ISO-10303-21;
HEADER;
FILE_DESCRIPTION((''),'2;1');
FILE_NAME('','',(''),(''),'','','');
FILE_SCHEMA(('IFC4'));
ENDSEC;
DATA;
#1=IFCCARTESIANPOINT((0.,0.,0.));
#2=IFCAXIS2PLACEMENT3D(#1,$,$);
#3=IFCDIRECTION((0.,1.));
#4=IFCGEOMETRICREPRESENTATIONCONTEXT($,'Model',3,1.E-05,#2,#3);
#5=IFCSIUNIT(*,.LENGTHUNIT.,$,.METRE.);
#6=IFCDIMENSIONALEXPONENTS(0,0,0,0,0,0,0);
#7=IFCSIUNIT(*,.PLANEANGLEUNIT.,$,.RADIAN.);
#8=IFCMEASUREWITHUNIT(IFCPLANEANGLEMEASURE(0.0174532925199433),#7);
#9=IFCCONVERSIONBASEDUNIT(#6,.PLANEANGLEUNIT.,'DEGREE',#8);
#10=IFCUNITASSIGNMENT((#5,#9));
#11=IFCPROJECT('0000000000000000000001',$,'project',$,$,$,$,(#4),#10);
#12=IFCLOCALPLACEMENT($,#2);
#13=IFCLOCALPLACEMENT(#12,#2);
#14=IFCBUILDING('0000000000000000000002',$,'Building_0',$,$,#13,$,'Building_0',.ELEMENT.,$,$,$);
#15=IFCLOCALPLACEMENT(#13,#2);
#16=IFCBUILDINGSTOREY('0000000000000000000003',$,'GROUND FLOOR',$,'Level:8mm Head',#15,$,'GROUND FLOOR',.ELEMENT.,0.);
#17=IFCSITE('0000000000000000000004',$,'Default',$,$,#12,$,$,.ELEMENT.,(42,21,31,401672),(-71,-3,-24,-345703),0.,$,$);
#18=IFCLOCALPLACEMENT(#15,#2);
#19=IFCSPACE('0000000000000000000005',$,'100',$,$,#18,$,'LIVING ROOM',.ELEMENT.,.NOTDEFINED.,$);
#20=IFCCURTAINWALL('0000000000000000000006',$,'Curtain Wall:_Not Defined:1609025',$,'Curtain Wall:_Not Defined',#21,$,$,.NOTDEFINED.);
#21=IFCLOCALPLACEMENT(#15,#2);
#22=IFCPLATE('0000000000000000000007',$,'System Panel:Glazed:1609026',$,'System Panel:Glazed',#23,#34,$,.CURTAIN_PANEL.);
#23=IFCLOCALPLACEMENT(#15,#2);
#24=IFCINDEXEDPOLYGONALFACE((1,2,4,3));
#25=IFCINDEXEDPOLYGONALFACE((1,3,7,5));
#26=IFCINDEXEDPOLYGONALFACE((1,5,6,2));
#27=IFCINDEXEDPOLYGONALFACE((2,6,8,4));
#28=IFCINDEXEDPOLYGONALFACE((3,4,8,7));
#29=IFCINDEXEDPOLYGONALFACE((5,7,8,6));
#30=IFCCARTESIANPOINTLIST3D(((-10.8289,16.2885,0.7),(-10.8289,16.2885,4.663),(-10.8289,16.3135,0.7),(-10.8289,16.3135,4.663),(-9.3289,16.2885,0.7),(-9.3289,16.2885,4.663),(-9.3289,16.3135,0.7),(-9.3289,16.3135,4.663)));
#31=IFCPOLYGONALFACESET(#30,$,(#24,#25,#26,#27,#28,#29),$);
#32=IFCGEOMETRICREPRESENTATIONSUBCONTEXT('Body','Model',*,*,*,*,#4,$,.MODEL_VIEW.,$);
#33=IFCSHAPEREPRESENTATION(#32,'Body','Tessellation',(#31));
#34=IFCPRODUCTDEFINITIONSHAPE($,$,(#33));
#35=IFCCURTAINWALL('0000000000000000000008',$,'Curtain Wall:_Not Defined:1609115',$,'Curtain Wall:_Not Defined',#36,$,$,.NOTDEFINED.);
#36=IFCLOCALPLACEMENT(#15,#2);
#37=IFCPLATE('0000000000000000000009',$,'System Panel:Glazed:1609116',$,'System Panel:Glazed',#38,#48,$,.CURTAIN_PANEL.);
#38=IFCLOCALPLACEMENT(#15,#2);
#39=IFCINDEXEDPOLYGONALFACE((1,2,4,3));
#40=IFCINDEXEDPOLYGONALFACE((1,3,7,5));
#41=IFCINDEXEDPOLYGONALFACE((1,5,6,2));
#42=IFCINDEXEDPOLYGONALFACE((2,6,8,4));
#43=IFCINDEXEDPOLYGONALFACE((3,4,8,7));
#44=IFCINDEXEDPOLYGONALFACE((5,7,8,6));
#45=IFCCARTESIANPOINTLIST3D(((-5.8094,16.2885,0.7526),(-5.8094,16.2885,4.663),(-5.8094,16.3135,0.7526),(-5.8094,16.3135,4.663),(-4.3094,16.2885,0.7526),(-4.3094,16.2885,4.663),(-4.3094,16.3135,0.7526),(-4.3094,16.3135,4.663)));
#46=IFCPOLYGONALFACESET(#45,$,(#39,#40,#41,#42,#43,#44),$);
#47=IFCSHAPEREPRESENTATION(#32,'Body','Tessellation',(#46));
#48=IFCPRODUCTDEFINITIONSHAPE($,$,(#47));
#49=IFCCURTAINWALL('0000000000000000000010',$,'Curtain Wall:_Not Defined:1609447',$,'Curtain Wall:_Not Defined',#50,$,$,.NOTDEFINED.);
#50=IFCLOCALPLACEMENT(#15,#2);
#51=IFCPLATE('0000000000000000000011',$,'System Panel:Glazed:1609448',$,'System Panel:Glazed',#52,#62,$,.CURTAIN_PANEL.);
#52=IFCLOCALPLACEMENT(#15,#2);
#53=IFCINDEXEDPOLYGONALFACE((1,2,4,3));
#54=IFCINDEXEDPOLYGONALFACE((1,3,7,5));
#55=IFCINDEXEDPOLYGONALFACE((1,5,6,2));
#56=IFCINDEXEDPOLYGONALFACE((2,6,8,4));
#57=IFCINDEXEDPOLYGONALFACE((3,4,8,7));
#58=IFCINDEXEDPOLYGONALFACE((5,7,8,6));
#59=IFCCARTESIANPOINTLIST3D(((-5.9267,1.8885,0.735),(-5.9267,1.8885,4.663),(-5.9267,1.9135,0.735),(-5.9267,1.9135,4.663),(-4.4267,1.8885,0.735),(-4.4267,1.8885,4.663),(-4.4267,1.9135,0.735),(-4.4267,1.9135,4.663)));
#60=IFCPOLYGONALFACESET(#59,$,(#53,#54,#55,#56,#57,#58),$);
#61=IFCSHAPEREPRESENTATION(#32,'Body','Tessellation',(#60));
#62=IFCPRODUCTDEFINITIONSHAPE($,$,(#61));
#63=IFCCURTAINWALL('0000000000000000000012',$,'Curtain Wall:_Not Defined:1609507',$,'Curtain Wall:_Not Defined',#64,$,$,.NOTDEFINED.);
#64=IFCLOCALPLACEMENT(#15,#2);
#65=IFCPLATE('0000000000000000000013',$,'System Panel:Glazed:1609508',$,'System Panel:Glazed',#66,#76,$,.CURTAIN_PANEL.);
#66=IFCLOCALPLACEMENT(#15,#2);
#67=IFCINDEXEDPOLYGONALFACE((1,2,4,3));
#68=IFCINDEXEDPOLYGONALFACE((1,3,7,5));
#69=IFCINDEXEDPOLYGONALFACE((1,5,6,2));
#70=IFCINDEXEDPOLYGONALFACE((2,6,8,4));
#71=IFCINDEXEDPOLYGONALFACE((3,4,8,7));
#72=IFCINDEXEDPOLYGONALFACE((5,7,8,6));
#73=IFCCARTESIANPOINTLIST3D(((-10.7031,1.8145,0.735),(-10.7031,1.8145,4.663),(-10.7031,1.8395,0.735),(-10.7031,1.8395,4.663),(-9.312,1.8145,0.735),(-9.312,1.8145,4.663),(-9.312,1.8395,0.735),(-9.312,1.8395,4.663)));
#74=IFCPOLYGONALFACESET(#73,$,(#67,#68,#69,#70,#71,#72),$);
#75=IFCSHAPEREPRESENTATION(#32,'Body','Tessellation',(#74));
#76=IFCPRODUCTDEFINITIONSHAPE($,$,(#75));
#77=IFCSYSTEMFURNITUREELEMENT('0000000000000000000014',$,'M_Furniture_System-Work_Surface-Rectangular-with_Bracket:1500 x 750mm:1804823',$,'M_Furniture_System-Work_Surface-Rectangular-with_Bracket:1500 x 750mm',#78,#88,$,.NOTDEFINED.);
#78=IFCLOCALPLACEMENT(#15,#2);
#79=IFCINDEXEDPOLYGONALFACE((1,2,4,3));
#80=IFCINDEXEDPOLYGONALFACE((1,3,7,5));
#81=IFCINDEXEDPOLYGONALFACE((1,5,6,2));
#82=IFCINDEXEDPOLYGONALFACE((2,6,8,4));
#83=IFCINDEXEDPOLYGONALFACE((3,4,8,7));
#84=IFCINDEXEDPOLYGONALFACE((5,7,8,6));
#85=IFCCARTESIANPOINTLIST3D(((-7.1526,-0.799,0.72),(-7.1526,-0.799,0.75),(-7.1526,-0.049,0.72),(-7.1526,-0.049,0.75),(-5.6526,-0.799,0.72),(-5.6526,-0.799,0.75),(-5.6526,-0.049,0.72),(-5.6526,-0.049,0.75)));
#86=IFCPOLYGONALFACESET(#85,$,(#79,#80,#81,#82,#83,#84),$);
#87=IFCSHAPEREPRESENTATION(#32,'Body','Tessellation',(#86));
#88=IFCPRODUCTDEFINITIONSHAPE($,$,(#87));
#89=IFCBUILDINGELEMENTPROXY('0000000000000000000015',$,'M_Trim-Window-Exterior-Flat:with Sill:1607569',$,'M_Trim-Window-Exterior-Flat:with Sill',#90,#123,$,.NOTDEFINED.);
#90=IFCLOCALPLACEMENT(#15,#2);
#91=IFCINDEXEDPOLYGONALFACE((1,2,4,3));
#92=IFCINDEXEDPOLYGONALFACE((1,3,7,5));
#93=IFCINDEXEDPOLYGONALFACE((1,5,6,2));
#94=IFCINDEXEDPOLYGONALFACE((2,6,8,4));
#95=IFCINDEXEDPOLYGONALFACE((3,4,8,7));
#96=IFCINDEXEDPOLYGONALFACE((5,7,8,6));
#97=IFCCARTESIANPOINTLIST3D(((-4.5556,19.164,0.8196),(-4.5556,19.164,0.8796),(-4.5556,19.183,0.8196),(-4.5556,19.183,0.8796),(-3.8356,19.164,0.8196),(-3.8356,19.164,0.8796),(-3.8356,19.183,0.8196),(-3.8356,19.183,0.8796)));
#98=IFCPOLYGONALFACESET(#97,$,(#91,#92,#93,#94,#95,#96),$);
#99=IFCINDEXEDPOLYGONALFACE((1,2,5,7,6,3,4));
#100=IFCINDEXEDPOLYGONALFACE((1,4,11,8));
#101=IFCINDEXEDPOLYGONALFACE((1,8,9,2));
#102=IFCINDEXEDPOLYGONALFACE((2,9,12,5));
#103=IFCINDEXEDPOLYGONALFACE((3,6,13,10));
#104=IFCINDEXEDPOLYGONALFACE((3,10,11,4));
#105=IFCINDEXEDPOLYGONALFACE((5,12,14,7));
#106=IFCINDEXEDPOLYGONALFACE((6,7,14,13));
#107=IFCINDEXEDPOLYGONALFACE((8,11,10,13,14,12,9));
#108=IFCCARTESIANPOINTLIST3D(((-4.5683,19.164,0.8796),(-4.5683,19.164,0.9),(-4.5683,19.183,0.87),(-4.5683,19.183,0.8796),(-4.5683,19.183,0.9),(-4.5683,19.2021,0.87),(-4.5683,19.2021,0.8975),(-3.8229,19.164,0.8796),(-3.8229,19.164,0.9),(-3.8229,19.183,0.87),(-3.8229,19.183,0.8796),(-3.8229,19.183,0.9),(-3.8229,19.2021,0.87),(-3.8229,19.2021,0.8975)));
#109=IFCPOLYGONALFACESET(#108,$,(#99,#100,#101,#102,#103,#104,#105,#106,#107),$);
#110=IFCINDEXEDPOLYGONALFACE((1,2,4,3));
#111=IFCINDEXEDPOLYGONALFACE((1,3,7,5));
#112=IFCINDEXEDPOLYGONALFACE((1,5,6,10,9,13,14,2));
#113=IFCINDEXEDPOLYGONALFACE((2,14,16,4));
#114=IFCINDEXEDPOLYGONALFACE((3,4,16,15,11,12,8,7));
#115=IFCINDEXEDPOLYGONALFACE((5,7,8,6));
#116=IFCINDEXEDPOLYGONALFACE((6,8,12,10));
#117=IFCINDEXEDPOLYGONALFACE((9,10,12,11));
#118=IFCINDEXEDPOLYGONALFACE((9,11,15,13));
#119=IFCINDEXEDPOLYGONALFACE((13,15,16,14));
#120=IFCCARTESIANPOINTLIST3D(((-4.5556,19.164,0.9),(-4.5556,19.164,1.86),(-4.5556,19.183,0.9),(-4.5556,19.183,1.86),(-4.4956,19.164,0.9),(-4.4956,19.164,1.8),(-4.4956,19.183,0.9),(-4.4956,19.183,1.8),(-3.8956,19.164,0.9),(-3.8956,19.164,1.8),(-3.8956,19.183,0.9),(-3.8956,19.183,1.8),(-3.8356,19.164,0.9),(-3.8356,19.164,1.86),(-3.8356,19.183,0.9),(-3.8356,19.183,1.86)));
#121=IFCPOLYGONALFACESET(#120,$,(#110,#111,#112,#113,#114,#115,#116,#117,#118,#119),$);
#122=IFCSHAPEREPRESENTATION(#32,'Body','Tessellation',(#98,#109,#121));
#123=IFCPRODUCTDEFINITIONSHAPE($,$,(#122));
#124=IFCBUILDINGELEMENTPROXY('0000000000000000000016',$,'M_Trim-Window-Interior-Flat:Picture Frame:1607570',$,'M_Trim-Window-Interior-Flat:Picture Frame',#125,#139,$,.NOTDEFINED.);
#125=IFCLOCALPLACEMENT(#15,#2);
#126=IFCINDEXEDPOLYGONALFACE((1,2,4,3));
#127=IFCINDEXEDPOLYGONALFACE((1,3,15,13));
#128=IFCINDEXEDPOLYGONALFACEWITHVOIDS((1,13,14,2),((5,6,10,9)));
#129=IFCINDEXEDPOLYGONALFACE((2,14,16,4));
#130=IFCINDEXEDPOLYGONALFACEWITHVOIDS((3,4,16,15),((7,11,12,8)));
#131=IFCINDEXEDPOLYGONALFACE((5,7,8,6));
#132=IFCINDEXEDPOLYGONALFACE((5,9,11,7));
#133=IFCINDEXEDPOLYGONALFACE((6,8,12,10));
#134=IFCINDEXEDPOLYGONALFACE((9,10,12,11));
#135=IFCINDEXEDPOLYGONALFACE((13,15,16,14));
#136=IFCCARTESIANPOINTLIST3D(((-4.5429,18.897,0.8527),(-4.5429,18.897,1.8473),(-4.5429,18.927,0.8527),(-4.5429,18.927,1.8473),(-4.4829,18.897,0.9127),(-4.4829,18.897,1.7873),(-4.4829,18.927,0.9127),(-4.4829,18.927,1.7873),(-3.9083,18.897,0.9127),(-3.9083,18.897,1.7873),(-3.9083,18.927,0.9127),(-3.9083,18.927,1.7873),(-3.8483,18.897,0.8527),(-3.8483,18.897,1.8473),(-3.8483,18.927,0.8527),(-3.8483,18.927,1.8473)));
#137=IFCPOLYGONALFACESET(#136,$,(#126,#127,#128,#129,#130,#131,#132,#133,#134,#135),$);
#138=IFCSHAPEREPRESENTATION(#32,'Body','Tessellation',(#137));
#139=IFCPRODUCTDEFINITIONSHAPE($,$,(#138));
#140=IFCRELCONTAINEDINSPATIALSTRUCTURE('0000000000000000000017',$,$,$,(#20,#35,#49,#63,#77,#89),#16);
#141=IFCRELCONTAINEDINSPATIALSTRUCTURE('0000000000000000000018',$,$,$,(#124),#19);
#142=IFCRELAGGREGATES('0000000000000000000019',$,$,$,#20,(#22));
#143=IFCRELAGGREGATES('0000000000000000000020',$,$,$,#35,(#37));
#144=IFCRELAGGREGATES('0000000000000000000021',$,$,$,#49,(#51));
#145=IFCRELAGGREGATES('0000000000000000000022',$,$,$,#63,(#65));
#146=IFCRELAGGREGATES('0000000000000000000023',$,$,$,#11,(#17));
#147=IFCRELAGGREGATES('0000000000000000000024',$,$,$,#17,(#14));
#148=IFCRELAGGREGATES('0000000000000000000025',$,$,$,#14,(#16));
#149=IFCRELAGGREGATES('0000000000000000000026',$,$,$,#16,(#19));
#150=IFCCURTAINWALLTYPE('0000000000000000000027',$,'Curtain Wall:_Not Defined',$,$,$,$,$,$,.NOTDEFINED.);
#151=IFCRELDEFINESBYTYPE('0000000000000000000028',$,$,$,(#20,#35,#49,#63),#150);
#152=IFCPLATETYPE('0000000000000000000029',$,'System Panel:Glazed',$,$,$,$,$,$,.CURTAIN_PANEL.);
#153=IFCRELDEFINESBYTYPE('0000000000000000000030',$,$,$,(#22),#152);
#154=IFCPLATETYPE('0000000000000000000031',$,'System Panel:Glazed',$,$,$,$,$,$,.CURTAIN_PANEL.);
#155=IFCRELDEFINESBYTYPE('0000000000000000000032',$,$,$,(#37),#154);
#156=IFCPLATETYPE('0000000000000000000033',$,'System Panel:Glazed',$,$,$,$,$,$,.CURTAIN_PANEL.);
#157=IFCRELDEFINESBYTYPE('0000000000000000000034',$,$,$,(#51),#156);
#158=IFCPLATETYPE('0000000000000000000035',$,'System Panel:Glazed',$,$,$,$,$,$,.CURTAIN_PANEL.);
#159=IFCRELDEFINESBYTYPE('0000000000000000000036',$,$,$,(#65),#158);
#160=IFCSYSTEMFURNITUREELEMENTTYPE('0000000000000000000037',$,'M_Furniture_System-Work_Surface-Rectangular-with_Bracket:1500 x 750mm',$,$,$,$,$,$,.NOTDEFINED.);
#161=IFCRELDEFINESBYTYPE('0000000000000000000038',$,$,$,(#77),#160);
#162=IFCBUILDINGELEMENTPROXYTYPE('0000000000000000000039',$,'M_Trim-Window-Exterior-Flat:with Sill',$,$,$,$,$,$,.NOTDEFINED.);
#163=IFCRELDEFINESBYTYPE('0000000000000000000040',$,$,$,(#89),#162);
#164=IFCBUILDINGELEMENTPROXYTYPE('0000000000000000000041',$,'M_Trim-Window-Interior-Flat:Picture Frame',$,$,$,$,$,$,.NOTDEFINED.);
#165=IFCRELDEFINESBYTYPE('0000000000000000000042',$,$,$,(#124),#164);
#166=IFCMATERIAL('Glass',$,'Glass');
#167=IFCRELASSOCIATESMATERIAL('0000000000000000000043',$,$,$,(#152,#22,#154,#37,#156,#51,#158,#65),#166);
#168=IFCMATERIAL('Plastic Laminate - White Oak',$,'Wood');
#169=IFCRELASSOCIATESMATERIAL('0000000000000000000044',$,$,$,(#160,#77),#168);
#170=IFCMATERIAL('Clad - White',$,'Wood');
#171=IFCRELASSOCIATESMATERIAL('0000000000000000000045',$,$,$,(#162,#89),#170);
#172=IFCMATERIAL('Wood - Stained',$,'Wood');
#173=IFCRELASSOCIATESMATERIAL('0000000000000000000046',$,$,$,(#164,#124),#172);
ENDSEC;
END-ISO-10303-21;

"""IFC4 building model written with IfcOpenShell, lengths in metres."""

from ifc_helpers import new_model, entity, si_unit, converted_unit, direction, frame, origin, place, context, subcontext, project, spatial, indexed_curve, outline, extrude, source, transform, mapped, material, type_object, type_shapes, element, aggregate, save


model = new_model("IFC4")

# Units and contexts
model_context = context("Model", 3, precision=1e-05, world=origin(), true_north=direction((0.0, 1.0)))
body_context = subcontext(model_context, "Body", "Model", "MODEL_VIEW")
ifc_project = project(units=[si_unit("LENGTHUNIT", "METRE"), converted_unit("PLANEANGLEUNIT", "DEGREE", entity("IfcPlaneAngleMeasure", 0.0174532925199433), si_unit("PLANEANGLEUNIT", "RADIAN"), dimensions=[0, 0, 0, 0, 0, 0, 0])], contexts=[model_context])

# Site, building, storey
site_placement = place(None, origin())
site = spatial("IfcSite", under=ifc_project, at=site_placement, Name="Default", CompositionType="ELEMENT", RefLatitude=(42, 21, 31, 401672), RefLongitude=(-71, -3, -24, -345703), RefElevation=0.0)
building_placement = place(site_placement, origin())
building = spatial("IfcBuilding", under=site, at=building_placement, Name="Building_0", LongName="Building_0", CompositionType="ELEMENT")
storey_placement = place(building_placement, origin())
storey = spatial("IfcBuildingStorey", under=building, at=storey_placement, Name="GROUND FLOOR", ObjectType="Level:8mm Head", LongName="GROUND FLOOR", CompositionType="ELEMENT", Elevation=0.0)

# Curtain walls, plates
curtain_wall_type = type_object("IfcCurtainWallType", Name="Curtain Wall:_Not Defined", PredefinedType="NOTDEFINED")
curtain_wall_1_placement = place(storey_placement, origin())
curtain_wall_1 = element("IfcCurtainWall", 1, at=curtain_wall_1_placement, inside=storey, type_object=curtain_wall_type, Name="Curtain Wall:_Not Defined:1609025", ObjectType="Curtain Wall:_Not Defined", PredefinedType="NOTDEFINED")
ifc_material_1 = material(Name="Glass", Category="Glass")
plate_type_1 = type_object("IfcPlateType", Name="System Panel:Glazed", PredefinedType="CURTAIN_PANEL", material=ifc_material_1)
shared_shape_1 = source(origin(), body_context, "Body", "SweptSolid", [
    extrude(outline(indexed_curve([(-0.0125, -0.75), (0.0125, -0.75), (0.0125, 0.75), (-0.0125, 0.75), (-0.0125, -0.75)], self_intersect=False)), frame((0.0, 0.037, 0.0), z_axis=(0.0, 0.0, 1.0), x_axis=(0.0, 1.0, 0.0)), (0.0, 0.0, 1.0), 3.963),
])
type_shapes(plate_type_1, [shared_shape_1])
plate_1_placement = place(curtain_wall_1_placement, frame((-10.0789, 16.264, 0.7)))
plate_1 = element("IfcPlate", 2, at=plate_1_placement, type_object=plate_type_1, material=ifc_material_1, Name="System Panel:Glazed:1609026", ObjectType="System Panel:Glazed", PredefinedType="CURTAIN_PANEL", context=body_context, shape_type="MappedRepresentation", body=[
    mapped(shared_shape_1, transform((0.0, 0.0, 0.0), scale=1.0)),
])
aggregate(curtain_wall_1, [plate_1])
curtain_wall_2_placement = place(storey_placement, origin())
curtain_wall_2 = element("IfcCurtainWall", 3, at=curtain_wall_2_placement, inside=storey, type_object=curtain_wall_type, Name="Curtain Wall:_Not Defined:1609115", ObjectType="Curtain Wall:_Not Defined", PredefinedType="NOTDEFINED")
plate_type_2 = type_object("IfcPlateType", Name="System Panel:Glazed", PredefinedType="CURTAIN_PANEL", material=ifc_material_1)
shared_shape_2 = source(origin(), body_context, "Body", "SweptSolid", [
    extrude(outline(indexed_curve([(-0.0125, -0.75), (0.0125, -0.75), (0.0125, 0.75), (-0.0125, 0.75), (-0.0125, -0.75)], self_intersect=False)), frame((0.0, 0.037, 0.0), z_axis=(0.0, 0.0, 1.0), x_axis=(0.0, 1.0, 0.0)), (0.0, 0.0, 1.0), 3.9104),
])
type_shapes(plate_type_2, [shared_shape_2])
plate_2_placement = place(curtain_wall_2_placement, frame((-5.0594, 16.264, 0.7526)))
plate_2 = element("IfcPlate", 4, at=plate_2_placement, type_object=plate_type_2, material=ifc_material_1, Name="System Panel:Glazed:1609116", ObjectType="System Panel:Glazed", PredefinedType="CURTAIN_PANEL", context=body_context, shape_type="MappedRepresentation", body=[
    mapped(shared_shape_2, transform((0.0, 0.0, 0.0), scale=1.0)),
])
aggregate(curtain_wall_2, [plate_2])
curtain_wall_3_placement = place(storey_placement, origin())
curtain_wall_3 = element("IfcCurtainWall", 5, at=curtain_wall_3_placement, inside=storey, type_object=curtain_wall_type, Name="Curtain Wall:_Not Defined:1609447", ObjectType="Curtain Wall:_Not Defined", PredefinedType="NOTDEFINED")
plate_type_3 = type_object("IfcPlateType", Name="System Panel:Glazed", PredefinedType="CURTAIN_PANEL", material=ifc_material_1)
shared_shape_3 = source(origin(), body_context, "Body", "SweptSolid", [
    extrude(outline(indexed_curve([(-0.0125, -0.75), (0.0125, -0.75), (0.0125, 0.75), (-0.0125, 0.75), (-0.0125, -0.75)], self_intersect=False)), frame((0.0, 0.037, 0.0), z_axis=(0.0, 0.0, 1.0), x_axis=(0.0, 1.0, 0.0)), (0.0, 0.0, 1.0), 3.928),
])
type_shapes(plate_type_3, [shared_shape_3])
plate_3_placement = place(curtain_wall_3_placement, frame((-5.1767, 1.864, 0.735)))
plate_3 = element("IfcPlate", 6, at=plate_3_placement, type_object=plate_type_3, material=ifc_material_1, Name="System Panel:Glazed:1609448", ObjectType="System Panel:Glazed", PredefinedType="CURTAIN_PANEL", context=body_context, shape_type="MappedRepresentation", body=[
    mapped(shared_shape_3, transform((0.0, 0.0, 0.0), scale=1.0)),
])
aggregate(curtain_wall_3, [plate_3])
curtain_wall_4_placement = place(storey_placement, origin())
curtain_wall_4 = element("IfcCurtainWall", 7, at=curtain_wall_4_placement, inside=storey, type_object=curtain_wall_type, Name="Curtain Wall:_Not Defined:1609507", ObjectType="Curtain Wall:_Not Defined", PredefinedType="NOTDEFINED")
plate_type_4 = type_object("IfcPlateType", Name="System Panel:Glazed", PredefinedType="CURTAIN_PANEL", material=ifc_material_1)
shared_shape_4 = source(origin(), body_context, "Body", "SweptSolid", [
    extrude(outline(indexed_curve([(-0.0125, -0.6955), (0.0125, -0.6955), (0.0125, 0.6955), (-0.0125, 0.6955), (-0.0125, -0.6955)], self_intersect=False)), frame((0.0, 0.037, 0.0), z_axis=(0.0, 0.0, 1.0), x_axis=(0.0, 1.0, 0.0)), (0.0, 0.0, 1.0), 3.928),
])
type_shapes(plate_type_4, [shared_shape_4])
plate_4_placement = place(curtain_wall_4_placement, frame((-10.0076, 1.864, 0.735), z_axis=(0.0, 0.0, 1.0), x_axis=(-1.0, 0.0, 0.0)))
plate_4 = element("IfcPlate", 8, at=plate_4_placement, type_object=plate_type_4, material=ifc_material_1, Name="System Panel:Glazed:1609508", ObjectType="System Panel:Glazed", PredefinedType="CURTAIN_PANEL", context=body_context, shape_type="MappedRepresentation", body=[
    mapped(shared_shape_4, transform((0.0, 0.0, 0.0), scale=1.0)),
])
aggregate(curtain_wall_4, [plate_4])

# System furniture element
ifc_material_2 = material(Name="Plastic Laminate - White Oak", Category="Wood")
system_furniture_element_type_1 = type_object("IfcSystemFurnitureElementType", Name="M_Furniture_System-Work_Surface-Rectangular-with_Bracket:1500 x 750mm", PredefinedType="NOTDEFINED", material=ifc_material_2)
shared_shape_5 = source(origin(), body_context, "Body", "SweptSolid", [
    extrude(outline(indexed_curve([(-0.75, -0.375), (0.75, -0.375), (0.75, 0.375), (-0.75, 0.375), (-0.75, -0.375)], self_intersect=False)), frame((0.75, -0.375, 0.72), z_axis=(0.0, 0.0, 1.0), x_axis=(-1.0, 0.0, 0.0)), (0.0, 0.0, 1.0), 0.03),
])
type_shapes(system_furniture_element_type_1, [shared_shape_5])
placement = place(storey_placement, origin())
system_furniture_element_1_placement = place(placement, frame((-7.1526, -0.049, 0.0)))
element("IfcSystemFurnitureElement", 9, at=system_furniture_element_1_placement, inside=storey, type_object=system_furniture_element_type_1, material=ifc_material_2, Name="M_Furniture_System-Work_Surface-Rectangular-with_Bracket:1500 x 750mm:1804823", ObjectType="M_Furniture_System-Work_Surface-Rectangular-with_Bracket:1500 x 750mm", PredefinedType="NOTDEFINED", context=body_context, shape_type="MappedRepresentation", body=[
    mapped(shared_shape_5, transform((0.0, 0.0, 0.0), scale=1.0)),
])

# Building element proxy
ifc_material_3 = material(Name="Clad - White", Category="Wood")
building_element_proxy_type_1 = type_object("IfcBuildingElementProxyType", Name="M_Trim-Window-Exterior-Flat:with Sill", PredefinedType="NOTDEFINED", material=ifc_material_3)
shared_shape_6 = source(origin(), body_context, "Body", "SweptSolid", [
    extrude(outline(indexed_curve([(-0.03, -0.36), (0.03, -0.36), (0.03, 0.36), (-0.03, 0.36), (-0.03, -0.36)], self_intersect=False)), frame((0.0, 0.9504, 0.0), z_axis=(0.0, 0.0, 1.0), x_axis=(0.0, 1.0, 0.0)), (0.0, 0.0, 1.0), 0.0191),
    extrude(outline(indexed_curve([(-0.0152, -0.019), (0.0123, -0.019), (0.0148, 0.0), (0.0148, 0.019), (-0.0057, 0.019), (-0.0057, 0.0), (-0.0152, 0.0), (-0.0152, -0.019)], self_intersect=False)), frame((-0.3727, 0.9148, 0.019), z_axis=(1.0, 0.0, 0.0), x_axis=(0.0, -1.0, 0.0)), (0.0, 0.0, 1.0), 0.7454),
    extrude(outline(indexed_curve([(-0.36, -0.495), (0.36, -0.495), (0.36, 0.465), (0.3, 0.465), (0.3, -0.435), (-0.3, -0.435), (-0.3, 0.465), (-0.36, 0.465), (-0.36, -0.495)], self_intersect=False)), frame((0.0, 0.435, 0.0)), (0.0, 0.0, 1.0), 0.0191),
])
type_shapes(building_element_proxy_type_1, [shared_shape_6])
proxy_1_placement = place(storey_placement, frame((-4.1956, 19.164, 1.8), z_axis=(0.0, 1.0, 0.0), x_axis=(1.0, 0.0, 0.0)))
element("IfcBuildingElementProxy", 10, at=proxy_1_placement, inside=storey, type_object=building_element_proxy_type_1, material=ifc_material_3, Name="M_Trim-Window-Exterior-Flat:with Sill:1607569", ObjectType="M_Trim-Window-Exterior-Flat:with Sill", PredefinedType="NOTDEFINED", context=body_context, shape_type="MappedRepresentation", body=[
    mapped(shared_shape_6, transform((0.0, 0.0, 0.0), scale=1.0)),
])

# Shared definitions
space_1_placement = place(storey_placement, origin())
space_1 = spatial("IfcSpace", under=storey, at=space_1_placement, Name="100", LongName="LIVING ROOM", CompositionType="ELEMENT", PredefinedType="NOTDEFINED")

# Building element proxy
ifc_material_4 = material(Name="Wood - Stained", Category="Wood")
building_element_proxy_type_2 = type_object("IfcBuildingElementProxyType", Name="M_Trim-Window-Interior-Flat:Picture Frame", PredefinedType="NOTDEFINED", material=ifc_material_4)
shared_shape_7 = source(origin(), body_context, "Body", "SweptSolid", [
    extrude(outline(indexed_curve([(-0.4973, -0.3473), (0.4973, -0.3473), (0.4973, 0.3473), (-0.4973, 0.3473), (-0.4973, -0.3473)], self_intersect=False), holes=[indexed_curve([(-0.4373, -0.2873), (-0.4373, 0.2873), (0.4373, 0.2873), (0.4373, -0.2873), (-0.4373, -0.2873)], self_intersect=False)]), frame((0.0, 0.45, 0.0), z_axis=(0.0, 0.0, 1.0), x_axis=(0.0, 1.0, 0.0)), (0.0, 0.0, 1.0), 0.03),
])
type_shapes(building_element_proxy_type_2, [shared_shape_7])
proxy_2_placement = place(space_1_placement, frame((-4.1956, 18.927, 1.8), z_axis=(0.0, -1.0, 0.0), x_axis=(-1.0, 0.0, 0.0)))
element("IfcBuildingElementProxy", 11, at=proxy_2_placement, inside=space_1, type_object=building_element_proxy_type_2, material=ifc_material_4, Name="M_Trim-Window-Interior-Flat:Picture Frame:1607570", ObjectType="M_Trim-Window-Interior-Flat:Picture Frame", PredefinedType="NOTDEFINED", context=body_context, shape_type="MappedRepresentation", body=[
    mapped(shared_shape_7, transform((0.0, 0.0, 0.0), scale=1.0)),
])

save(model, "model.ifc")
